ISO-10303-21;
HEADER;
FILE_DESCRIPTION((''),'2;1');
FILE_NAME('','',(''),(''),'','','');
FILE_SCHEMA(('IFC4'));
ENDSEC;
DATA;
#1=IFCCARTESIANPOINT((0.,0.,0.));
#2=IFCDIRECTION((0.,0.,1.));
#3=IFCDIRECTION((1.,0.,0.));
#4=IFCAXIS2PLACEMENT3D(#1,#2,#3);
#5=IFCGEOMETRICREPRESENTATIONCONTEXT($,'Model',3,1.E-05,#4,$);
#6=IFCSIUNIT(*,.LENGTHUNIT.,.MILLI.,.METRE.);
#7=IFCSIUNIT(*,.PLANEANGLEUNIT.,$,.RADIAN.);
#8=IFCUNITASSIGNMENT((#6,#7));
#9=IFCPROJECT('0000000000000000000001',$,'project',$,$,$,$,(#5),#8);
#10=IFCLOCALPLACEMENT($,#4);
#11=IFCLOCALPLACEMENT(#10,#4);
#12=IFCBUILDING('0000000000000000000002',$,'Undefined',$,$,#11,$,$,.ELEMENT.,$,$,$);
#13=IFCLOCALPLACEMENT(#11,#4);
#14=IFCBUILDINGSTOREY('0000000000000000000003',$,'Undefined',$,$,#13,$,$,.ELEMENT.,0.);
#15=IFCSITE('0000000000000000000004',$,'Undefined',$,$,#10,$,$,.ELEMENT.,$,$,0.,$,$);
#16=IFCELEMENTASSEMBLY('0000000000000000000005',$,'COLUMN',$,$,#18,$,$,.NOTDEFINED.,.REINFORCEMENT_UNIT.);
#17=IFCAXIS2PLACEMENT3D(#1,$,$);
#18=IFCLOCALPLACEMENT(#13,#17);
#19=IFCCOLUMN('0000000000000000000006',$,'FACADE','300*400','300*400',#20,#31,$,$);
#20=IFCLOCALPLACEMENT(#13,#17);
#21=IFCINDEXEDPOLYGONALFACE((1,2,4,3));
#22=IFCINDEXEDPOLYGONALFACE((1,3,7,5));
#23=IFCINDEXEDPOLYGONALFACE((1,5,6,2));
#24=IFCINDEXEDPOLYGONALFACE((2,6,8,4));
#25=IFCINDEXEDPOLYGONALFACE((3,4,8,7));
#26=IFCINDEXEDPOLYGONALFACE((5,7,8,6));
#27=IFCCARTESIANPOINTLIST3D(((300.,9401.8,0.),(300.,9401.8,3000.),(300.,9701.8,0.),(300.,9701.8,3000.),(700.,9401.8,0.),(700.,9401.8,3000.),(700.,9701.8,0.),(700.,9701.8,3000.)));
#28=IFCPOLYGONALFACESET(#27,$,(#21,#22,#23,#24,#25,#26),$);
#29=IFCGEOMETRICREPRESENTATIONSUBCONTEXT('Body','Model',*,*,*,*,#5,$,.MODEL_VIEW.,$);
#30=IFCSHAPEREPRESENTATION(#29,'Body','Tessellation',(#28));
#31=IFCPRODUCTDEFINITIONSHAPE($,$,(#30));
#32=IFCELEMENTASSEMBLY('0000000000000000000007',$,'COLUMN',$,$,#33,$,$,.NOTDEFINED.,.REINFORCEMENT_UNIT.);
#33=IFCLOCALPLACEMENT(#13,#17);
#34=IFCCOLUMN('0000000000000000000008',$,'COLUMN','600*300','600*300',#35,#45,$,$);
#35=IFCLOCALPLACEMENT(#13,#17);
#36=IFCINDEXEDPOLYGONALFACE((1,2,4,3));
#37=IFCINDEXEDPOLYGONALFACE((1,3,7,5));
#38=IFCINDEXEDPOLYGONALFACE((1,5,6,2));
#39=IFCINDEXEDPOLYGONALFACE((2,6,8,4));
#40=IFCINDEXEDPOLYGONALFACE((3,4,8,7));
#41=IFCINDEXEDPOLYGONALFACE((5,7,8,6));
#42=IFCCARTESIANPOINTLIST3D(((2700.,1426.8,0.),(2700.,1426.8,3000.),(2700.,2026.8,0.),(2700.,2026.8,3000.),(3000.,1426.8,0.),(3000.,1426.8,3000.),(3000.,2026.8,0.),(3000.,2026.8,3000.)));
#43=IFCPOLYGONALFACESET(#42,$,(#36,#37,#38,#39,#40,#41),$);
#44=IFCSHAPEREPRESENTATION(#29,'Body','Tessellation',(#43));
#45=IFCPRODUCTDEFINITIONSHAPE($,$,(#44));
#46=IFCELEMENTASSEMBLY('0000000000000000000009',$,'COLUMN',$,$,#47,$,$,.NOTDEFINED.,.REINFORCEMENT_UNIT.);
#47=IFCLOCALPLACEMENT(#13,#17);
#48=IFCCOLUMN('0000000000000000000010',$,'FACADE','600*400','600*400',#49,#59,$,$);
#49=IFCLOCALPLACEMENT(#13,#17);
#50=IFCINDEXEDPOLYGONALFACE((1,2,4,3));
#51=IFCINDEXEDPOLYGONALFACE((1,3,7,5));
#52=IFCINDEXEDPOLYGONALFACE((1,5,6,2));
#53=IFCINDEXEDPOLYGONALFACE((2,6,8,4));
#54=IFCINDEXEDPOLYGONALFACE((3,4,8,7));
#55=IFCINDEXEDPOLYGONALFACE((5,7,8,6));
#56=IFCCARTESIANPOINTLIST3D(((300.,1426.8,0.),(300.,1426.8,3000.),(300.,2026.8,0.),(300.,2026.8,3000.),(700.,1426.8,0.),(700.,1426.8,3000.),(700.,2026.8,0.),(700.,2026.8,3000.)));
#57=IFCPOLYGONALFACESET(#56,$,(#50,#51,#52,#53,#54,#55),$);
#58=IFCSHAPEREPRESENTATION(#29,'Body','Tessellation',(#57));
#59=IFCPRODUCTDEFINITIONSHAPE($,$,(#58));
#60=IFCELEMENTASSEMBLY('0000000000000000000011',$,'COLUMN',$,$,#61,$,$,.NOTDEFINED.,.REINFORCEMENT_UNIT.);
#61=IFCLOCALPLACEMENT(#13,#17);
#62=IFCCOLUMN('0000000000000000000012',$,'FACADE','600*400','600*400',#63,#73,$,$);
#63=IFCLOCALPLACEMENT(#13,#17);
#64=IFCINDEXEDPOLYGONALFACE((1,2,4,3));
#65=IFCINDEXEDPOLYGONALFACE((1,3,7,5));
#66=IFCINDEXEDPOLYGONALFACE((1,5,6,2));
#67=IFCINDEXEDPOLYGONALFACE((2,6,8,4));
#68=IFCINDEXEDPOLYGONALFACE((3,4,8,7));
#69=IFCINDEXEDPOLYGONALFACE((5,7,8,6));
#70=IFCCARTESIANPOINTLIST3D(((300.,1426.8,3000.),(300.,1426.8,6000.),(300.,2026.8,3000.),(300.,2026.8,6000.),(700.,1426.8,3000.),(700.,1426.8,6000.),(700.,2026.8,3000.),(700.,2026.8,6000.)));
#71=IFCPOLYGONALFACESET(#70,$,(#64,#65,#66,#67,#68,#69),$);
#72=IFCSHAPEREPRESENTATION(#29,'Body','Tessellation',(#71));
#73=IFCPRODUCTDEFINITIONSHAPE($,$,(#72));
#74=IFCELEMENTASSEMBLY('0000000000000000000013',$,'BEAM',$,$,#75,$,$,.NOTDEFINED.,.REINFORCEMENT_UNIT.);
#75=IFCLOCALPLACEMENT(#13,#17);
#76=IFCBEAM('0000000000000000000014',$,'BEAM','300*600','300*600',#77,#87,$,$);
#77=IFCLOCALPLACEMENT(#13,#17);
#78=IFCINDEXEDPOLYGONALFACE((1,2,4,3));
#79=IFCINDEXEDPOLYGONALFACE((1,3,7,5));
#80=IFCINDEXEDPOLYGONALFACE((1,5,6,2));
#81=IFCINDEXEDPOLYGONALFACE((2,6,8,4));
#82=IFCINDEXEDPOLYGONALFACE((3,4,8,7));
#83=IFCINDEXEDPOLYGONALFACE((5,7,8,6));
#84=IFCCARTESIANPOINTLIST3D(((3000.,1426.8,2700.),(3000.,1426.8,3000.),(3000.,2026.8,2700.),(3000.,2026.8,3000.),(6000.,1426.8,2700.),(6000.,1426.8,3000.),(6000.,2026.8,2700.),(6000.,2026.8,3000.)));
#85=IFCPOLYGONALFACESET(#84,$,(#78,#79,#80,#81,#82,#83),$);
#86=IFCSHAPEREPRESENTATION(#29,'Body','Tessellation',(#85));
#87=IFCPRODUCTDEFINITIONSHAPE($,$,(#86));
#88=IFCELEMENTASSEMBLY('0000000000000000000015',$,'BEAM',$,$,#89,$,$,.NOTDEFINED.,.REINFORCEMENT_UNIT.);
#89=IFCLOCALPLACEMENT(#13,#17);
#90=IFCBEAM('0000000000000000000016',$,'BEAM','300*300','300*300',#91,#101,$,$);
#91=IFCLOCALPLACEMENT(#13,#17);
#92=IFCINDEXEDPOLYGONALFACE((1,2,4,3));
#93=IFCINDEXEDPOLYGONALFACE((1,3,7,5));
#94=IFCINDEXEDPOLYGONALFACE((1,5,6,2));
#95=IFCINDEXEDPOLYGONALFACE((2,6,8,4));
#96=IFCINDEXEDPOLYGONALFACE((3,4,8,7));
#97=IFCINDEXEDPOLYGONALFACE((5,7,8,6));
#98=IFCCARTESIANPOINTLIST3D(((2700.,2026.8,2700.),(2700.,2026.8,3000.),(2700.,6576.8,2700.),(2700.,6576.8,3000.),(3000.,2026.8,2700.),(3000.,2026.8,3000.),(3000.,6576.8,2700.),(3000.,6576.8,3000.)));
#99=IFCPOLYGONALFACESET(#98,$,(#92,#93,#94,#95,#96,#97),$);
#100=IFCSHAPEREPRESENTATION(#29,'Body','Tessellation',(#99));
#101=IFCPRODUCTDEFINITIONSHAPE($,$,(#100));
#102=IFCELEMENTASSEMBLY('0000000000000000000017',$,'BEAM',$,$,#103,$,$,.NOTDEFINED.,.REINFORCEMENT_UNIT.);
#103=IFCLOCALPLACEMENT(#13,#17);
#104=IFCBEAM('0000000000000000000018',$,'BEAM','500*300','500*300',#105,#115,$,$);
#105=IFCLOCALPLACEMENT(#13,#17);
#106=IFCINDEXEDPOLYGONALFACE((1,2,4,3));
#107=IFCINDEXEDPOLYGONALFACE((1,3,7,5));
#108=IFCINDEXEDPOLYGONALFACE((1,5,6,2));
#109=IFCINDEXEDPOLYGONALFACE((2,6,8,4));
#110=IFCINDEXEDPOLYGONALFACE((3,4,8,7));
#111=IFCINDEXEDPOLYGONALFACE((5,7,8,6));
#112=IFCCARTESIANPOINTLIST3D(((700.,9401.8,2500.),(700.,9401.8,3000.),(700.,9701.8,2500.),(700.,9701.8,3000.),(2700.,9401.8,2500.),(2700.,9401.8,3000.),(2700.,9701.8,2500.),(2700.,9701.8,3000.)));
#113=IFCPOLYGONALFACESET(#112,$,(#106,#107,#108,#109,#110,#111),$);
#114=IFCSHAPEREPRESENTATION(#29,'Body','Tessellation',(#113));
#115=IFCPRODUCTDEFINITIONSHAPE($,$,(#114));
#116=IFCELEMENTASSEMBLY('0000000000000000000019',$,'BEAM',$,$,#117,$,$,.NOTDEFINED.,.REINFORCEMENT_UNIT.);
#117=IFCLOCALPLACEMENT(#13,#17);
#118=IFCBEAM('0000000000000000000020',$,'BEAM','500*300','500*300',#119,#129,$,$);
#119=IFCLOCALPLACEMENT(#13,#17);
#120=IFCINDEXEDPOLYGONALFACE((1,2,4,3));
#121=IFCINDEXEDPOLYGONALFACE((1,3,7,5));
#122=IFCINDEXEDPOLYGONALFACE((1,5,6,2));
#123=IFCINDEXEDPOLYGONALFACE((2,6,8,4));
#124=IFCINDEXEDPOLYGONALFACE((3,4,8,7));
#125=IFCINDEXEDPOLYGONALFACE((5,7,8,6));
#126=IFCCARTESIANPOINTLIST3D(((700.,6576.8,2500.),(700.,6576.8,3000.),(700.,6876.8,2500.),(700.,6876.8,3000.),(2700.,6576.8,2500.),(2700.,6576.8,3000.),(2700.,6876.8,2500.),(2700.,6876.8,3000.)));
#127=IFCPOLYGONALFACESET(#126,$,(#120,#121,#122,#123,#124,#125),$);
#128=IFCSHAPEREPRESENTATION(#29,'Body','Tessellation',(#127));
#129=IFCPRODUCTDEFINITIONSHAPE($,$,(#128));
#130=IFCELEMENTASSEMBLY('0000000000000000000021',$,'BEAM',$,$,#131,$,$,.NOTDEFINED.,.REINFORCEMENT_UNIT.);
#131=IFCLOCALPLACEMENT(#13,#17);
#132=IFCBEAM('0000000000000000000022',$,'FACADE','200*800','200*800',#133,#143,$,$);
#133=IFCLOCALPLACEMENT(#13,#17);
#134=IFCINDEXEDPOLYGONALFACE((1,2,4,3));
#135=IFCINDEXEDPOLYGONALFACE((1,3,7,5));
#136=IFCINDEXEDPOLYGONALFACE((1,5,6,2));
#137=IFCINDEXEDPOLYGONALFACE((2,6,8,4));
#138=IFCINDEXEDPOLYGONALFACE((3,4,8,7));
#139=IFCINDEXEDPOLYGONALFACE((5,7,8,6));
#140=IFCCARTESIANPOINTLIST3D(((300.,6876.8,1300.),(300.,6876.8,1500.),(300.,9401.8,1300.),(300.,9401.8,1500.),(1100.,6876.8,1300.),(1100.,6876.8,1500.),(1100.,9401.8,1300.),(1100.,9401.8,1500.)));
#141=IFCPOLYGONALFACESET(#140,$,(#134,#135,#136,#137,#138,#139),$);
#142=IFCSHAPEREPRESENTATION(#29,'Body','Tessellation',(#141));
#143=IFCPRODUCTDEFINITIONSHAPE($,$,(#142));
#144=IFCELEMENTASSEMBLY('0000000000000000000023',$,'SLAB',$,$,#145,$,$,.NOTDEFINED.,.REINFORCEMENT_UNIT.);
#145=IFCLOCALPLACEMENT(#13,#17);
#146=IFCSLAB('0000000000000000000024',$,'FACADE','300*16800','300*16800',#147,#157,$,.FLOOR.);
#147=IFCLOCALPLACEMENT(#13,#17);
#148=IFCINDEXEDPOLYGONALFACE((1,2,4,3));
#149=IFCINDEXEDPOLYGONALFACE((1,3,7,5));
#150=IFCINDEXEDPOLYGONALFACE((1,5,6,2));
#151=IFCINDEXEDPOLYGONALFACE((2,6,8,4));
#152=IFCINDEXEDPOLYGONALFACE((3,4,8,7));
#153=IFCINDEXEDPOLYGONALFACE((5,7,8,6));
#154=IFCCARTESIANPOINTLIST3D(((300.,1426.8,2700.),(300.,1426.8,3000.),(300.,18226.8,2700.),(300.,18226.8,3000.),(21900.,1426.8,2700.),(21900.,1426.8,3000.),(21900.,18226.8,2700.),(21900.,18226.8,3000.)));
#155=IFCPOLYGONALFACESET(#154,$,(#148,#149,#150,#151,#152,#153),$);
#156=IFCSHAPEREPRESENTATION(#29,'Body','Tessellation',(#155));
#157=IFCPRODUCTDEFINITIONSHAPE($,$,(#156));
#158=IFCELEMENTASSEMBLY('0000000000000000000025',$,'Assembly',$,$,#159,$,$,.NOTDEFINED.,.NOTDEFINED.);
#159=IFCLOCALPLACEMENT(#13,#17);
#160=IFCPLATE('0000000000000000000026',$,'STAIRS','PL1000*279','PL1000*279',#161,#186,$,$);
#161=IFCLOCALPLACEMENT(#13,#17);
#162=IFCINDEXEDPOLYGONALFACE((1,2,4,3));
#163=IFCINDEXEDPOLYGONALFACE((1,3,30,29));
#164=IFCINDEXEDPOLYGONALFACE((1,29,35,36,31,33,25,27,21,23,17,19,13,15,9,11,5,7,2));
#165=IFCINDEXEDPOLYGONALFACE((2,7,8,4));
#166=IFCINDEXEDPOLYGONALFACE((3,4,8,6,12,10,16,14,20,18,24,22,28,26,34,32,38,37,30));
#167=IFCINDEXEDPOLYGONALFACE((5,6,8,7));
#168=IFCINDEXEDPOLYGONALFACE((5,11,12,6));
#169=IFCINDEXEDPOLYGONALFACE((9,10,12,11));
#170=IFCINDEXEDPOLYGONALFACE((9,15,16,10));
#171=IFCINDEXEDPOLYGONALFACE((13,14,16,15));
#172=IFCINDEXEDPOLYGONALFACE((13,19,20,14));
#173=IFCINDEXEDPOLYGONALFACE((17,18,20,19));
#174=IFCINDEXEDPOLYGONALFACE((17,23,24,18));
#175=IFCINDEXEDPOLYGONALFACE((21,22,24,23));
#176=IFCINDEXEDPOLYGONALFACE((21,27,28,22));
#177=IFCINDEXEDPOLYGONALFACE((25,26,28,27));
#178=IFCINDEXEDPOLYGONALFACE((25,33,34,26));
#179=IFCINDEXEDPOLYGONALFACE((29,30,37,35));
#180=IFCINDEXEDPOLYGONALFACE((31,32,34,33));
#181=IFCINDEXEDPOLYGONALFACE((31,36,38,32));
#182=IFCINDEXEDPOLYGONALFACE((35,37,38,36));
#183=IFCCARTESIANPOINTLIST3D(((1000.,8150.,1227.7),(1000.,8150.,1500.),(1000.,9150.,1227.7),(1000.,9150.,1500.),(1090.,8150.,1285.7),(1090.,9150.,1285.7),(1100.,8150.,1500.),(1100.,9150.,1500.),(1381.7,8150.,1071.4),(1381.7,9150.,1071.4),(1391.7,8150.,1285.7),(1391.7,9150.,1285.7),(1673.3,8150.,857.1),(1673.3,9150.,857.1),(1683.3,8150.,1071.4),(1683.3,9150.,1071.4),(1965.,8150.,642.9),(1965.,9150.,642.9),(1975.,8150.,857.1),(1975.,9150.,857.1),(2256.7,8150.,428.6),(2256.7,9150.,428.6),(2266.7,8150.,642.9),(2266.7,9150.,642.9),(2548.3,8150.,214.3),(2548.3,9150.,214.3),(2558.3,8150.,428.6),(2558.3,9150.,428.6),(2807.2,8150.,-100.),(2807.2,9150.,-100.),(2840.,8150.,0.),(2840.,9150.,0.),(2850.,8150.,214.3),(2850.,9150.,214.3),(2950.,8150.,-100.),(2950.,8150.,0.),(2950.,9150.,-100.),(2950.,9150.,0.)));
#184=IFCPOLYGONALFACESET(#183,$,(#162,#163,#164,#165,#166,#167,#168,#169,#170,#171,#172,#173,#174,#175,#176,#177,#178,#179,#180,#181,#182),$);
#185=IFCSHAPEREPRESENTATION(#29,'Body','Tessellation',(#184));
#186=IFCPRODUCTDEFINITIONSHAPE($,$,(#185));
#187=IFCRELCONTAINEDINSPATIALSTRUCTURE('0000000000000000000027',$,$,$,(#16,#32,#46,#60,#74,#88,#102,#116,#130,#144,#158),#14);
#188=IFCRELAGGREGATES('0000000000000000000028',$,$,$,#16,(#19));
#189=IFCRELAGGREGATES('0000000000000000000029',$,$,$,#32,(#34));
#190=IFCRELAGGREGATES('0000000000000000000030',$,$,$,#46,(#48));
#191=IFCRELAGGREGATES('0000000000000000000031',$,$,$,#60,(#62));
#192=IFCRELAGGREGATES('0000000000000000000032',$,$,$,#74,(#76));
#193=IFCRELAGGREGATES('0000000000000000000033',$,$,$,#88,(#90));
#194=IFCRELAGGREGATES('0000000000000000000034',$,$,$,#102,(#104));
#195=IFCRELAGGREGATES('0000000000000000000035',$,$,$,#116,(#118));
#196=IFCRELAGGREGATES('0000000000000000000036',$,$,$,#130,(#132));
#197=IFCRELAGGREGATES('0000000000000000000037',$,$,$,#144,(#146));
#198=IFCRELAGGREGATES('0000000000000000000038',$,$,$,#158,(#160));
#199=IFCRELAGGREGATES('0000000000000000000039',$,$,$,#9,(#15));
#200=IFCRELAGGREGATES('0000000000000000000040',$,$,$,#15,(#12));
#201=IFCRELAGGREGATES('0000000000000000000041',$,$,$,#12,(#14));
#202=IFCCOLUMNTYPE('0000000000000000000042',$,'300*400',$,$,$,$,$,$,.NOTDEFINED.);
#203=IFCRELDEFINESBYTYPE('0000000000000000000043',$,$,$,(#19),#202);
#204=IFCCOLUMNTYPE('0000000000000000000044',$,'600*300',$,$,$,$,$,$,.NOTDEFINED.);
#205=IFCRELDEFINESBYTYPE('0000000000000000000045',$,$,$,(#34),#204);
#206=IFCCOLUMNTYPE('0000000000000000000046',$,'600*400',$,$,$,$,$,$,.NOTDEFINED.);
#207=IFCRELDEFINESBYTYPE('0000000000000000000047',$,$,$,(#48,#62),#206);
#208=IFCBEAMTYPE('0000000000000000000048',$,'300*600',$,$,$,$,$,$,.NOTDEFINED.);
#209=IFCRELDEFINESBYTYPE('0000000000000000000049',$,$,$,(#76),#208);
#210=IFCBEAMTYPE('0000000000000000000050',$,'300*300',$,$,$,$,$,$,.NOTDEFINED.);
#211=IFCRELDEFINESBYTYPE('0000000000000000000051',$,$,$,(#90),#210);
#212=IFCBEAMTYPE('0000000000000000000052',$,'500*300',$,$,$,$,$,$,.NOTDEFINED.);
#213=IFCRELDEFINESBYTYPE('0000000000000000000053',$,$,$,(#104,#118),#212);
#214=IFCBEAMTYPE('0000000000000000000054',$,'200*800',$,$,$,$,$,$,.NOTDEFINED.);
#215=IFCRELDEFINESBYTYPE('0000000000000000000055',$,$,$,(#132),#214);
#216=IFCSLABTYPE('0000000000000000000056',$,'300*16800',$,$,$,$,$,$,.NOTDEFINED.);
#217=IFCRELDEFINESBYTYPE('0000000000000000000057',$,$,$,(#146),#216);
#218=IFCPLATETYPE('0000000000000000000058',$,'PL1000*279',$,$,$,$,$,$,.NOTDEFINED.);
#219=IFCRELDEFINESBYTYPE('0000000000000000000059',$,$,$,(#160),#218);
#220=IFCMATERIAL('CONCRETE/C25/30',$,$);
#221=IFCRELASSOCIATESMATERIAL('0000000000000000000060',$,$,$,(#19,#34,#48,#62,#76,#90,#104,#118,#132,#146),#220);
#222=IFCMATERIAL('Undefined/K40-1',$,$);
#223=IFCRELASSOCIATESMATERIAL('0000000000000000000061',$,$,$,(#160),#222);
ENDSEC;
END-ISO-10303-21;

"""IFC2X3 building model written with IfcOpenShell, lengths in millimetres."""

from ifc_helpers import new_model, si_unit, frame, origin_with_axes, origin_2d_with_axis, place, context, subcontext, project, spatial, polyline, rectangle, outline, extrude, material, type_object, element, aggregate, save


model = new_model("IFC2X3")

# Units and contexts
model_context = context("Model", 3, precision=1e-05, world=origin_with_axes())
body_context = subcontext(model_context, "Body", "Model", "MODEL_VIEW")
ifc_project = project(units=[si_unit("LENGTHUNIT", "METRE", prefix="MILLI"), si_unit("PLANEANGLEUNIT", "RADIAN")], contexts=[model_context])

# Site, building, storey
site_placement = place(None, origin_with_axes())
site = spatial("IfcSite", under=ifc_project, at=site_placement, Name="Undefined", CompositionType="ELEMENT", RefElevation=0.0)
building_placement = place(site_placement, origin_with_axes())
building = spatial("IfcBuilding", under=site, at=building_placement, Name="Undefined", CompositionType="ELEMENT")
storey_placement = place(building_placement, origin_with_axes())
storey = spatial("IfcBuildingStorey", under=building, at=storey_placement, Name="Undefined", CompositionType="ELEMENT", Elevation=0.0)

# Shared definitions
ifc_material_1 = material(Name="CONCRETE/C25/30")

# Element assemblies, columns
column_type_1 = type_object("IfcColumnType", Name="300*400", PredefinedType="NOTDEFINED")
assembly_1_placement = place(storey_placement, origin_with_axes())
assembly_1 = element("IfcElementAssembly", 1, at=assembly_1_placement, inside=storey, Name="COLUMN", AssemblyPlace="NOTDEFINED", PredefinedType="REINFORCEMENT_UNIT")
column_1_placement = place(assembly_1_placement, frame((500.0, 9551.8, 0.0), z_axis=(0.0, 0.0, 1.0), x_axis=(1.0, 0.0, 0.0)))
column_1 = element("IfcColumn", 2, at=column_1_placement, type_object=column_type_1, material=ifc_material_1, Name="FACADE", Description="300*400", ObjectType="300*400", context=body_context, shape_type="SweptSolid", body=[
    extrude(rectangle(XDim=400.0, YDim=300.0, at=origin_2d_with_axis()), frame((0.0, 0.0, 3000.0), z_axis=(0.0, 0.0, -1.0), x_axis=(-1.0, 0.0, 0.0)), (0.0, 0.0, 1.0), 3000.0),
])
aggregate(assembly_1, [column_1])
assembly_2_placement = place(storey_placement, origin_with_axes())
assembly_2 = element("IfcElementAssembly", 3, at=assembly_2_placement, inside=storey, Name="COLUMN", AssemblyPlace="NOTDEFINED", PredefinedType="REINFORCEMENT_UNIT")
column_type_2 = type_object("IfcColumnType", Name="600*300", PredefinedType="NOTDEFINED")
column_2_placement = place(assembly_2_placement, frame((2850.0, 1726.8, 0.0), z_axis=(0.0, 0.0, 1.0), x_axis=(1.0, 0.0, 0.0)))
column_2 = element("IfcColumn", 4, at=column_2_placement, type_object=column_type_2, material=ifc_material_1, Name="COLUMN", Description="600*300", ObjectType="600*300", context=body_context, shape_type="SweptSolid", body=[
    extrude(rectangle(XDim=300.0, YDim=600.0, at=origin_2d_with_axis()), frame((0.0, 0.0, 3000.0), z_axis=(0.0, 0.0, -1.0), x_axis=(-1.0, 0.0, 0.0)), (0.0, 0.0, 1.0), 3000.0),
])
aggregate(assembly_2, [column_2])
assembly_3_placement = place(storey_placement, origin_with_axes())
assembly_3 = element("IfcElementAssembly", 5, at=assembly_3_placement, inside=storey, Name="COLUMN", AssemblyPlace="NOTDEFINED", PredefinedType="REINFORCEMENT_UNIT")
column_type_3 = type_object("IfcColumnType", Name="600*400", PredefinedType="NOTDEFINED")
column_3_placement = place(assembly_3_placement, frame((500.0, 1726.8, 0.0), z_axis=(0.0, 0.0, 1.0), x_axis=(1.0, 0.0, 0.0)))
column_3 = element("IfcColumn", 6, at=column_3_placement, type_object=column_type_3, material=ifc_material_1, Name="FACADE", Description="600*400", ObjectType="600*400", context=body_context, shape_type="SweptSolid", body=[
    extrude(rectangle(XDim=400.0, YDim=600.0, at=origin_2d_with_axis()), frame((0.0, 0.0, 3000.0), z_axis=(0.0, 0.0, -1.0), x_axis=(-1.0, 0.0, 0.0)), (0.0, 0.0, 1.0), 3000.0),
])
aggregate(assembly_3, [column_3])
assembly_4_placement = place(storey_placement, origin_with_axes())
assembly_4 = element("IfcElementAssembly", 7, at=assembly_4_placement, inside=storey, Name="COLUMN", AssemblyPlace="NOTDEFINED", PredefinedType="REINFORCEMENT_UNIT")
column_4_placement = place(assembly_4_placement, frame((500.0, 1726.8, 3000.0), z_axis=(0.0, 0.0, 1.0), x_axis=(1.0, 0.0, 0.0)))
column_4 = element("IfcColumn", 8, at=column_4_placement, type_object=column_type_3, material=ifc_material_1, Name="FACADE", Description="600*400", ObjectType="600*400", context=body_context, shape_type="SweptSolid", body=[
    extrude(rectangle(XDim=400.0, YDim=600.0, at=origin_2d_with_axis()), frame((0.0, 0.0, 3000.0), z_axis=(0.0, 0.0, -1.0), x_axis=(-1.0, 0.0, 0.0)), (0.0, 0.0, 1.0), 3000.0),
])
aggregate(assembly_4, [column_4])

# Element assemblies, beams
beam_type_1 = type_object("IfcBeamType", Name="300*600", PredefinedType="NOTDEFINED")
assembly_5_placement = place(storey_placement, origin_with_axes())
assembly_5 = element("IfcElementAssembly", 9, at=assembly_5_placement, inside=storey, Name="BEAM", AssemblyPlace="NOTDEFINED", PredefinedType="REINFORCEMENT_UNIT")
beam_1_placement = place(assembly_5_placement, frame((2850.0, 1726.8, 2850.0), z_axis=(0.0, 0.0, 1.0), x_axis=(1.0, 0.0, 0.0)))
beam_1 = element("IfcBeam", 10, at=beam_1_placement, type_object=beam_type_1, material=ifc_material_1, Name="BEAM", Description="300*600", ObjectType="300*600", context=body_context, shape_type="SweptSolid", body=[
    extrude(rectangle(XDim=600.0, YDim=300.0, at=origin_2d_with_axis()), frame((3150.0, 0.0, 0.0), z_axis=(-1.0, 0.0, 0.0), x_axis=(0.0, -1.0, 0.0)), (0.0, 0.0, 1.0), 3000.0),
])
aggregate(assembly_5, [beam_1])
assembly_6_placement = place(storey_placement, origin_with_axes())
assembly_6 = element("IfcElementAssembly", 11, at=assembly_6_placement, inside=storey, Name="BEAM", AssemblyPlace="NOTDEFINED", PredefinedType="REINFORCEMENT_UNIT")
beam_type_2 = type_object("IfcBeamType", Name="300*300", PredefinedType="NOTDEFINED")
beam_2_placement = place(assembly_6_placement, frame((2850.0, 6576.8, 2850.0), z_axis=(0.0, 0.0, 1.0), x_axis=(0.0, -1.0, 0.0)))
beam_2 = element("IfcBeam", 12, at=beam_2_placement, type_object=beam_type_2, material=ifc_material_1, Name="BEAM", Description="300*300", ObjectType="300*300", context=body_context, shape_type="SweptSolid", body=[
    extrude(rectangle(XDim=300.0, YDim=300.0, at=origin_2d_with_axis()), frame((4550.0, 0.0, 0.0), z_axis=(-1.0, 0.0, 0.0), x_axis=(0.0, -1.0, 0.0)), (0.0, 0.0, 1.0), 4550.0),
])
aggregate(assembly_6, [beam_2])
beam_type_3 = type_object("IfcBeamType", Name="500*300", PredefinedType="NOTDEFINED")
assembly_7_placement = place(storey_placement, origin_with_axes())
assembly_7 = element("IfcElementAssembly", 13, at=assembly_7_placement, inside=storey, Name="BEAM", AssemblyPlace="NOTDEFINED", PredefinedType="REINFORCEMENT_UNIT")
beam_3_placement = place(assembly_7_placement, frame((500.0, 9551.8, 2750.0), z_axis=(0.0, 0.0, 1.0), x_axis=(1.0, 0.0, 0.0)))
beam_3 = element("IfcBeam", 14, at=beam_3_placement, type_object=beam_type_3, material=ifc_material_1, Name="BEAM", Description="500*300", ObjectType="500*300", context=body_context, shape_type="SweptSolid", body=[
    extrude(rectangle(XDim=300.0, YDim=500.0, at=origin_2d_with_axis()), frame((2200.0, 0.0, 0.0), z_axis=(-1.0, 0.0, 0.0), x_axis=(0.0, -1.0, 0.0)), (0.0, 0.0, 1.0), 2000.0),
])
aggregate(assembly_7, [beam_3])
assembly_8_placement = place(storey_placement, origin_with_axes())
assembly_8 = element("IfcElementAssembly", 15, at=assembly_8_placement, inside=storey, Name="BEAM", AssemblyPlace="NOTDEFINED", PredefinedType="REINFORCEMENT_UNIT")
beam_4_placement = place(assembly_8_placement, frame((700.0, 6726.8, 2750.0), z_axis=(0.0, 0.0, 1.0), x_axis=(1.0, 0.0, 0.0)))
beam_4 = element("IfcBeam", 16, at=beam_4_placement, type_object=beam_type_3, material=ifc_material_1, Name="BEAM", Description="500*300", ObjectType="500*300", context=body_context, shape_type="SweptSolid", body=[
    extrude(rectangle(XDim=300.0, YDim=500.0, at=origin_2d_with_axis()), frame((2000.0, 0.0, 0.0), z_axis=(-1.0, 0.0, 0.0), x_axis=(0.0, -1.0, 0.0)), (0.0, 0.0, 1.0), 2000.0),
])
aggregate(assembly_8, [beam_4])
assembly_9_placement = place(storey_placement, origin_with_axes())
assembly_9 = element("IfcElementAssembly", 17, at=assembly_9_placement, inside=storey, Name="BEAM", AssemblyPlace="NOTDEFINED", PredefinedType="REINFORCEMENT_UNIT")
beam_type_4 = type_object("IfcBeamType", Name="200*800", PredefinedType="NOTDEFINED")
beam_5_placement = place(assembly_9_placement, frame((700.0, 9401.8, 1400.0), z_axis=(0.0, 0.0, 1.0), x_axis=(0.0, -1.0, 0.0)))
beam_5 = element("IfcBeam", 18, at=beam_5_placement, type_object=beam_type_4, material=ifc_material_1, Name="FACADE", Description="200*800", ObjectType="200*800", context=body_context, shape_type="SweptSolid", body=[
    extrude(rectangle(XDim=800.0, YDim=200.0, at=origin_2d_with_axis()), frame((2525.0, 0.0, 0.0), z_axis=(-1.0, 0.0, 0.0), x_axis=(0.0, -1.0, 0.0)), (0.0, 0.0, 1.0), 2525.0),
])
aggregate(assembly_9, [beam_5])

# Element assembly, slab
assembly_10_placement = place(storey_placement, origin_with_axes())
assembly_10 = element("IfcElementAssembly", 19, at=assembly_10_placement, inside=storey, Name="SLAB", AssemblyPlace="NOTDEFINED", PredefinedType="REINFORCEMENT_UNIT")
slab_type = type_object("IfcSlabType", Name="300*16800", PredefinedType="NOTDEFINED")
slab_placement = place(assembly_10_placement, frame((300.0, 1426.8, 2850.0), z_axis=(0.0, 0.0, 1.0), x_axis=(1.0, 0.0, 0.0)))
slab = element("IfcSlab", 20, at=slab_placement, type_object=slab_type, material=ifc_material_1, Name="FACADE", Description="300*16800", ObjectType="300*16800", PredefinedType="FLOOR", context=body_context, shape_type="SweptSolid", body=[
    extrude(outline(polyline([(0.0, 0.0), (21600.0, 0.0), (21600.0, 16800.0), (0.0, 16800.0), (0.0, 0.0), (0.0, 0.0)])), frame((0.0, 0.0, -150.0), z_axis=(0.0, 0.0, 1.0), x_axis=(1.0, 0.0, 0.0)), (0.0, 0.0, 1.0), 300.0),
])
aggregate(assembly_10, [slab])

# Element assembly, plate
assembly_11_placement = place(storey_placement, origin_with_axes())
assembly_11 = element("IfcElementAssembly", 21, at=assembly_11_placement, inside=storey, Name="Assembly", AssemblyPlace="NOTDEFINED", PredefinedType="NOTDEFINED")
ifc_material_2 = material(Name="Undefined/K40-1")
plate_type_1 = type_object("IfcPlateType", Name="PL1000*279", PredefinedType="NOTDEFINED")
plate_1_placement = place(assembly_11_placement, frame((2840.0, 8650.0, 0.0), z_axis=(0.0, 1.0, 0.0), x_axis=(1.0, 0.0, 0.0)))
plate_1 = element("IfcPlate", 22, at=plate_1_placement, type_object=plate_type_1, material=ifc_material_2, Name="STAIRS", Description="PL1000*279", ObjectType="PL1000*279", context=body_context, shape_type="SweptSolid", body=[
    extrude(outline(polyline([(0.0, 0.0), (110.0, 0.0), (110.0, 100.0), (-32.8, 100.0), (-1840.0, -1227.7), (-1840.0, -1500.0), (-1740.0, -1500.0), (-1750.0, -1285.7), (-1448.3, -1285.7), (-1458.3, -1071.4), (-1156.7, -1071.4), (-1166.7, -857.1), (-865.0, -857.1), (-875.0, -642.9), (-573.3, -642.9), (-583.3, -428.6), (-281.7, -428.6), (-291.7, -214.3), (10.0, -214.3), (0.0, 0.0), (0.0, 0.0)])), frame((0.0, 0.0, -500.0), z_axis=(0.0, 0.0, 1.0), x_axis=(1.0, 0.0, 0.0)), (0.0, 0.0, 1.0), 1000.0),
])
aggregate(assembly_11, [plate_1])

save(model, "model.ifc")
